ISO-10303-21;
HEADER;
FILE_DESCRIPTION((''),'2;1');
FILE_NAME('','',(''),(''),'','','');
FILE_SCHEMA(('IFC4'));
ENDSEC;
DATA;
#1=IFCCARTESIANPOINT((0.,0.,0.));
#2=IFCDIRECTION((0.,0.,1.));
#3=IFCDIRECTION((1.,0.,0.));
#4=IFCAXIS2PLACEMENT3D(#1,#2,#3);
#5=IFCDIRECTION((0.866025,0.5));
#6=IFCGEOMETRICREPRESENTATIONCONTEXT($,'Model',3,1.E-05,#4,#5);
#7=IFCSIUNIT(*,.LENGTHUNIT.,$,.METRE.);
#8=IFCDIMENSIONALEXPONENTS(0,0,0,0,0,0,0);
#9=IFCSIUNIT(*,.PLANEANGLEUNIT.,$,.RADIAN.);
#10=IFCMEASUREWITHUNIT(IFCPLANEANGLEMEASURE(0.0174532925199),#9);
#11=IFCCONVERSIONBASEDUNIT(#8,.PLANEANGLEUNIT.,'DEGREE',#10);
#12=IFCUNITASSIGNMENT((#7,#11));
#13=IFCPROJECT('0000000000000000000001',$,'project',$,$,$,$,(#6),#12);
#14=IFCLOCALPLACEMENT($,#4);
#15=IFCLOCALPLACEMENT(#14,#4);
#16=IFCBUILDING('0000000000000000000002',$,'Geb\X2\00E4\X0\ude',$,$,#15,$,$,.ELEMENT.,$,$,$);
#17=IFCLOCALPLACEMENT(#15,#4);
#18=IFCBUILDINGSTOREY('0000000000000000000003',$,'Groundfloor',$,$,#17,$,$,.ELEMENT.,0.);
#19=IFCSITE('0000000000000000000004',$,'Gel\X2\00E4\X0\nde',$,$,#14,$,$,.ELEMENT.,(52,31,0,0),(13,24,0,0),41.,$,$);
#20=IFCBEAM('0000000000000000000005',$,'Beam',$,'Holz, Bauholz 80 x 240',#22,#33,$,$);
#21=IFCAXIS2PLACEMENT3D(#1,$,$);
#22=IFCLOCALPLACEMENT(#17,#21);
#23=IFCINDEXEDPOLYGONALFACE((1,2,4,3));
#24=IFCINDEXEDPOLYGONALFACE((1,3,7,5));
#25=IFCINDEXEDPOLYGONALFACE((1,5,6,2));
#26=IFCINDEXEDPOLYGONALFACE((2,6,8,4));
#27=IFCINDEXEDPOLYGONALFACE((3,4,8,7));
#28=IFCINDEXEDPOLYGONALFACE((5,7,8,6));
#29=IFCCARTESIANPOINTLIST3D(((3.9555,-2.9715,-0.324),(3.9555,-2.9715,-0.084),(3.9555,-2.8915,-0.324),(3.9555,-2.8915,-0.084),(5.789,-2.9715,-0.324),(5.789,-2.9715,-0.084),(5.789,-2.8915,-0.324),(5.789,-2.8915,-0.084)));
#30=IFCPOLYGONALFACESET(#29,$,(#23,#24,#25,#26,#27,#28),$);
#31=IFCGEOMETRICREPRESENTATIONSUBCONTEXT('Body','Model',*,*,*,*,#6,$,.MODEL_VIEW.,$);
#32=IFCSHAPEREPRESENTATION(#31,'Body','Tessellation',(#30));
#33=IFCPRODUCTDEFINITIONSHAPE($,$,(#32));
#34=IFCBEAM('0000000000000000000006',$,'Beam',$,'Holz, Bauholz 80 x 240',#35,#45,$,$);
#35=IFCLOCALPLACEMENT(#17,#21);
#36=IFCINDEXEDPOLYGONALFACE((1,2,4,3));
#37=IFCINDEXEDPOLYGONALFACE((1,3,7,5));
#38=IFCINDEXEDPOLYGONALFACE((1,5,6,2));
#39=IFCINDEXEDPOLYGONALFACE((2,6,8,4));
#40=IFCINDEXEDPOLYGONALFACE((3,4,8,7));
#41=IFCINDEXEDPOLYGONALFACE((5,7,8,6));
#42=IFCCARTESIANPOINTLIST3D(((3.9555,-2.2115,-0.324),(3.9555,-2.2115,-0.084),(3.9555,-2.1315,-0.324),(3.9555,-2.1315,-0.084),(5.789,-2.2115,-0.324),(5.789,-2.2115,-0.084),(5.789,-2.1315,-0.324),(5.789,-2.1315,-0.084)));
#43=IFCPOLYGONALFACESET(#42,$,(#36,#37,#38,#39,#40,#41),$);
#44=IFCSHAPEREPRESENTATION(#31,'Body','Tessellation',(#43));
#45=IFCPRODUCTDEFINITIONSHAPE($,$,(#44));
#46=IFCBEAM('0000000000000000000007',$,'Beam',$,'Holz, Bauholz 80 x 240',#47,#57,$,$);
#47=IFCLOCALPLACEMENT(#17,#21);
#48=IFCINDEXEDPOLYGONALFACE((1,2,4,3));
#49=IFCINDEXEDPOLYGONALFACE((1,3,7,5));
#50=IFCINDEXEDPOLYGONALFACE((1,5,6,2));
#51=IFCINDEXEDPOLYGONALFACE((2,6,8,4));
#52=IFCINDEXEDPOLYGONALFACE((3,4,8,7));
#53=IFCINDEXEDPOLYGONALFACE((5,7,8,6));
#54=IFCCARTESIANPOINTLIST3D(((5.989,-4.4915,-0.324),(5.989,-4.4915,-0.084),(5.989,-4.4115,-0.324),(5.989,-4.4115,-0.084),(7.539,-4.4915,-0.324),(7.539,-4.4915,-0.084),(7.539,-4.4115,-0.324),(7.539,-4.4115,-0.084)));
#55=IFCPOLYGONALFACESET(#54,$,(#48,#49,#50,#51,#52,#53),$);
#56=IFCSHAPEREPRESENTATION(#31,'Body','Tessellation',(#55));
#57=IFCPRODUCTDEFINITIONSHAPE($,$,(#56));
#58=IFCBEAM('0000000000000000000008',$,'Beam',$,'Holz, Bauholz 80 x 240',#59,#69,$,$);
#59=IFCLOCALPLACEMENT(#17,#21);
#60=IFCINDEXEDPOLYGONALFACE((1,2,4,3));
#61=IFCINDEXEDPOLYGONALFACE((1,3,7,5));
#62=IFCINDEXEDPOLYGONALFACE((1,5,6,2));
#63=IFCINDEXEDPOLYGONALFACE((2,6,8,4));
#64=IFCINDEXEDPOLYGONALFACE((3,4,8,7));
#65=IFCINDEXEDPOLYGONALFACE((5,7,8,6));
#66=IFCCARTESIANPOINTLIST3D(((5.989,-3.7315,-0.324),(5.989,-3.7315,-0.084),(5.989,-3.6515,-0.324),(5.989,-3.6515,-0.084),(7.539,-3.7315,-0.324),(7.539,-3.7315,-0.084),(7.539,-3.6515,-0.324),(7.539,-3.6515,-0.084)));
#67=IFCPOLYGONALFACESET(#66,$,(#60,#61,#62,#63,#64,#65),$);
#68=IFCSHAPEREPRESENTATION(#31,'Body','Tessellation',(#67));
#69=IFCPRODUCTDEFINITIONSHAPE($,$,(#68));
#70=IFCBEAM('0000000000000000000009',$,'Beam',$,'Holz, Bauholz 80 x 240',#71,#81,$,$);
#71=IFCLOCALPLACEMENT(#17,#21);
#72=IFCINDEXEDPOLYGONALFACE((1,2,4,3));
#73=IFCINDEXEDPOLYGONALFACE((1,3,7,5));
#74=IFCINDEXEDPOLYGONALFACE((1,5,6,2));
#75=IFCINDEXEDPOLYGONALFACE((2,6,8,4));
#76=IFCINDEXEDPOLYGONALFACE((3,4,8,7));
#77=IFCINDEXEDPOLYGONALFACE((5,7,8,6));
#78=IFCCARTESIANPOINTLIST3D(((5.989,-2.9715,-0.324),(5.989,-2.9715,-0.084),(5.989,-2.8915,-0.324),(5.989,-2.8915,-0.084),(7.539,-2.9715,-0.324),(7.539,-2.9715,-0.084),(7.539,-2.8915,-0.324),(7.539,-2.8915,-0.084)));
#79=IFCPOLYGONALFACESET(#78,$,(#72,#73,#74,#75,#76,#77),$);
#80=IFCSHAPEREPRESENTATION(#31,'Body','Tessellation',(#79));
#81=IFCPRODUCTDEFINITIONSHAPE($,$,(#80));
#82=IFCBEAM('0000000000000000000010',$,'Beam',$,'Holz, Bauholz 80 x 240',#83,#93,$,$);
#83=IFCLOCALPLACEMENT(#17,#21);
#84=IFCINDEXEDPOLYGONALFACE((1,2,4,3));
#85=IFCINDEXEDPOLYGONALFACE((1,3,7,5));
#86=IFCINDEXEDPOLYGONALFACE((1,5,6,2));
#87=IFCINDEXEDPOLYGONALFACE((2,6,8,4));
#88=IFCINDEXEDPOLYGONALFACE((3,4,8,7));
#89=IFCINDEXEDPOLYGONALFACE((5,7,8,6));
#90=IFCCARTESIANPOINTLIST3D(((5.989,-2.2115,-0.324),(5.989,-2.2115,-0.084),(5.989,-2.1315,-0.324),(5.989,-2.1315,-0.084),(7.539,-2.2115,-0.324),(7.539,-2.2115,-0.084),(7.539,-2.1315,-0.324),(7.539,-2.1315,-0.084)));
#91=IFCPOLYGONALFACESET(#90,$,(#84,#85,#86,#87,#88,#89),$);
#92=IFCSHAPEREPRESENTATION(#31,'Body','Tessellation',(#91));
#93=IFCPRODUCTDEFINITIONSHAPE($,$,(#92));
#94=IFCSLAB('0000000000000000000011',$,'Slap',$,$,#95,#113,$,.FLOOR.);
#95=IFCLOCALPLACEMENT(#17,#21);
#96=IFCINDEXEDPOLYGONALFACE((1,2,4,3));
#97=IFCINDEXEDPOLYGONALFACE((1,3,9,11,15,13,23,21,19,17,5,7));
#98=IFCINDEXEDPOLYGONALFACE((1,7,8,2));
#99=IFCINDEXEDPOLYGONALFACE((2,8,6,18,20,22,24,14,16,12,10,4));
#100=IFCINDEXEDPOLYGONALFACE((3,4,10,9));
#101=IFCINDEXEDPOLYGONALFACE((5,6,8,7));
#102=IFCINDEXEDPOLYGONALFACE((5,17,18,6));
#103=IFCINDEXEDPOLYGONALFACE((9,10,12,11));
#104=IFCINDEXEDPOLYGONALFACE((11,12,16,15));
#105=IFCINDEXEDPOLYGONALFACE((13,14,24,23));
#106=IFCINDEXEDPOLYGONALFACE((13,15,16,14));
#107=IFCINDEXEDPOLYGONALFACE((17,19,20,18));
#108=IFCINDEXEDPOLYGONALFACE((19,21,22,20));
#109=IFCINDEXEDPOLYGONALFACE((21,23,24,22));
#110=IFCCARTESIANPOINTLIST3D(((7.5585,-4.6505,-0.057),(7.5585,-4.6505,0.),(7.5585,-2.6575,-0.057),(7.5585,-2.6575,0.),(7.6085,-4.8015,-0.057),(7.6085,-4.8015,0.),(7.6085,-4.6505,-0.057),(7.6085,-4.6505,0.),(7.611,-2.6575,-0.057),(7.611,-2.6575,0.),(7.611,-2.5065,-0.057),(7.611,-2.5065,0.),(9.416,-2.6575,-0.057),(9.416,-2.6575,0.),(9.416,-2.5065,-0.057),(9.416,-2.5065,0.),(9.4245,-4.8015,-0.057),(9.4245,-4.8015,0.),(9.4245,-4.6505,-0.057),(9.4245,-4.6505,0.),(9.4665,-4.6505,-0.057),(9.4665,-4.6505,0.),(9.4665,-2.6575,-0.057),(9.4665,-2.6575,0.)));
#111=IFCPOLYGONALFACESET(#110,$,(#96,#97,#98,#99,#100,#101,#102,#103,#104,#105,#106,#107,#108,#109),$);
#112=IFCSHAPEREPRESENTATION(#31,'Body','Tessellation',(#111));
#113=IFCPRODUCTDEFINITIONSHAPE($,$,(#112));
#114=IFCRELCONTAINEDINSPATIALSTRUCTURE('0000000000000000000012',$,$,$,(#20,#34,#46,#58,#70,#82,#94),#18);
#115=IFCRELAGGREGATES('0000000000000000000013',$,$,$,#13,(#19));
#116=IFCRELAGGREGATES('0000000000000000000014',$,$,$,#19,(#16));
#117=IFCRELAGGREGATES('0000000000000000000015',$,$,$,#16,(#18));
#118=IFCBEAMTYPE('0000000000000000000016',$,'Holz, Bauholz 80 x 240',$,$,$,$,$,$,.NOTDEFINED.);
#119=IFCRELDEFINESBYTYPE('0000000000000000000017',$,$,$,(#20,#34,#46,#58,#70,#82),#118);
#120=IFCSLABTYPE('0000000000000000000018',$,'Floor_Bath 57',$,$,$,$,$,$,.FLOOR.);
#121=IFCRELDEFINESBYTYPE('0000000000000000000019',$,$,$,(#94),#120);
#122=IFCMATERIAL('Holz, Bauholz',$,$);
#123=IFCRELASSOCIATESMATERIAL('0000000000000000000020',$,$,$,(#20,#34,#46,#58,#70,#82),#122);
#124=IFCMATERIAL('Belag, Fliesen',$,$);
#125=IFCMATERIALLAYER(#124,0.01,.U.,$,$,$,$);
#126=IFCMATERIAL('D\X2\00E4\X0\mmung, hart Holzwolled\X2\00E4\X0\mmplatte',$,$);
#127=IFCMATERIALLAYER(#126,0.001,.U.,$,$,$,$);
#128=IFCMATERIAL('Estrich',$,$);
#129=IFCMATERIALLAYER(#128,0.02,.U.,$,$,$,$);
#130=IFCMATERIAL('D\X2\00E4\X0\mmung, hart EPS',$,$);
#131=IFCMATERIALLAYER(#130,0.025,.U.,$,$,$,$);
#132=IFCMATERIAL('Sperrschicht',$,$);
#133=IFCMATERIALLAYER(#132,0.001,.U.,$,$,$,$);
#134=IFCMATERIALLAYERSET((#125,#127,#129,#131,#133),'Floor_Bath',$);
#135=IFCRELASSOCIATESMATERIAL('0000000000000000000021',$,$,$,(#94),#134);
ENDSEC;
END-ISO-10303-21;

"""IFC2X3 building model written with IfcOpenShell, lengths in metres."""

from ifc_helpers import new_model, entity, si_unit, converted_unit, direction, frame, frame_2d, origin_with_axes, place, context, subcontext, project, spatial, polyline, rectangle, outline, extrude, material, layer, layer_set, layer_usage, type_object, element, save


model = new_model("IFC2X3")

# Units and contexts
model_context = context("Model", 3, precision=1e-05, world=origin_with_axes(), true_north=direction((0.866025, 0.5)))
body_context = subcontext(model_context, "Body", "Model", "MODEL_VIEW")
ifc_project = project(units=[si_unit("LENGTHUNIT", "METRE"), converted_unit("PLANEANGLEUNIT", "DEGREE", entity("IfcPlaneAngleMeasure", 0.0174532925199), si_unit("PLANEANGLEUNIT", "RADIAN"), dimensions=[0, 0, 0, 0, 0, 0, 0])], contexts=[model_context])

# Site, building, storey
site_placement = place(None, origin_with_axes())
site = spatial("IfcSite", under=ifc_project, at=site_placement, Name="Gelände", CompositionType="ELEMENT", RefLatitude=(52, 31, 0, 0), RefLongitude=(13, 24, 0, 0), RefElevation=41.0)
building_placement = place(site_placement, origin_with_axes())
building = spatial("IfcBuilding", under=site, at=building_placement, Name="Gebäude", CompositionType="ELEMENT")
storey_placement = place(building_placement, origin_with_axes())
storey = spatial("IfcBuildingStorey", under=building, at=storey_placement, Name="Groundfloor", CompositionType="ELEMENT", Elevation=0.0)

# Shared definitions
ifc_material_1 = material(Name="Holz, Bauholz")

# Beams
beam_type = type_object("IfcBeamType", Name="Holz, Bauholz 80 x 240", PredefinedType="NOTDEFINED")
for number, where, z_axis, x_axis, name in (
    (1, (5.789, -2.9315, -0.084), (0.0, 0.0, 1.0), (0.0, 1.0, 0.0), "Beam"),
    (2, (5.789, -2.1715, -0.084), (0.0, 0.0, 1.0), (0.0, 1.0, 0.0), "Beam"),
):
    element("IfcBeam", number, at=place(storey_placement, frame(where, z_axis=z_axis, x_axis=x_axis)), inside=storey, type_object=beam_type, material=ifc_material_1, Name=name, ObjectType="Holz, Bauholz 80 x 240", context=body_context, shape_type="SweptSolid", body=[
        extrude(rectangle(XDim=0.24, YDim=0.08, at=frame_2d((-0.12, 0.0), x_axis=(1.0, 0.0))), frame((0.0, 0.0, 0.0), z_axis=(0.0, 1.0, 0.0), x_axis=(0.0, 0.0, 1.0)), (0.0, 0.0, 1.0), 1.8335),
    ])
for number, where, z_axis, x_axis, name in (
    (3, (7.539, -4.4515, -0.084), (0.0, 0.0, 1.0), (0.0, 1.0, 0.0), "Beam"),
    (4, (7.539, -3.6915, -0.084), (0.0, 0.0, 1.0), (0.0, 1.0, 0.0), "Beam"),
    (5, (7.539, -2.9315, -0.084), (0.0, 0.0, 1.0), (0.0, 1.0, 0.0), "Beam"),
    (6, (7.539, -2.1715, -0.084), (0.0, 0.0, 1.0), (0.0, 1.0, 0.0), "Beam"),
):
    element("IfcBeam", number, at=place(storey_placement, frame(where, z_axis=z_axis, x_axis=x_axis)), inside=storey, type_object=beam_type, material=ifc_material_1, Name=name, ObjectType="Holz, Bauholz 80 x 240", context=body_context, shape_type="SweptSolid", body=[
        extrude(rectangle(XDim=0.24, YDim=0.08, at=frame_2d((-0.12, 0.0), x_axis=(1.0, 0.0))), frame((0.0, 0.0, 0.0), z_axis=(0.0, 1.0, 0.0), x_axis=(0.0, 0.0, 1.0)), (0.0, 0.0, 1.0), 1.55),
    ])

# Slab
ifc_material_2 = material(Name="Belag, Fliesen")
ifc_layer_1 = layer(ifc_material_2, 0.01, ventilated="UNKNOWN")
ifc_material_3 = material(Name="Dämmung, hart Holzwolledämmplatte")
ifc_layer_2 = layer(ifc_material_3, 0.001, ventilated="UNKNOWN")
ifc_material_4 = material(Name="Estrich")
ifc_layer_3 = layer(ifc_material_4, 0.02, ventilated="UNKNOWN")
ifc_material_5 = material(Name="Dämmung, hart EPS")
ifc_layer_4 = layer(ifc_material_5, 0.025, ventilated="UNKNOWN")
ifc_material_6 = material(Name="Sperrschicht")
ifc_layer_5 = layer(ifc_material_6, 0.001, ventilated="UNKNOWN")
ifc_layer_set_1 = layer_set([ifc_layer_1, ifc_layer_2, ifc_layer_3, ifc_layer_4, ifc_layer_5], Name="Floor_Bath")
ifc_layer_usage_1 = layer_usage(ifc_layer_set_1, "AXIS3", "NEGATIVE", 0.057)
slab_type = type_object("IfcSlabType", Name="Floor_Bath 57", PredefinedType="FLOOR")
slab_placement = place(storey_placement, frame((7.5585, -2.6575, 0.0), z_axis=(0.0, 0.0, 1.0), x_axis=(1.0, 0.0, 0.0)))
element("IfcSlab", 7, at=slab_placement, inside=storey, type_object=slab_type, material=ifc_layer_usage_1, Name="Slap", PredefinedType="FLOOR", context=body_context, shape_type="SweptSolid", body=[
    extrude(outline(polyline([(0.0, 0.0), (0.0, -1.993), (0.05, -1.993), (0.05, -2.144), (1.866, -2.144), (1.866, -1.993), (1.908, -1.993), (1.908, 0.0), (1.8575, 0.0), (1.8575, 0.151), (0.0525, 0.151), (0.0525, 0.0), (0.0, 0.0)])), frame((0.0, 0.0, -0.057), z_axis=(0.0, 0.0, 1.0), x_axis=(1.0, 0.0, 0.0)), (0.0, 0.0, 1.0), 0.057),
])

save(model, "model.ifc")
